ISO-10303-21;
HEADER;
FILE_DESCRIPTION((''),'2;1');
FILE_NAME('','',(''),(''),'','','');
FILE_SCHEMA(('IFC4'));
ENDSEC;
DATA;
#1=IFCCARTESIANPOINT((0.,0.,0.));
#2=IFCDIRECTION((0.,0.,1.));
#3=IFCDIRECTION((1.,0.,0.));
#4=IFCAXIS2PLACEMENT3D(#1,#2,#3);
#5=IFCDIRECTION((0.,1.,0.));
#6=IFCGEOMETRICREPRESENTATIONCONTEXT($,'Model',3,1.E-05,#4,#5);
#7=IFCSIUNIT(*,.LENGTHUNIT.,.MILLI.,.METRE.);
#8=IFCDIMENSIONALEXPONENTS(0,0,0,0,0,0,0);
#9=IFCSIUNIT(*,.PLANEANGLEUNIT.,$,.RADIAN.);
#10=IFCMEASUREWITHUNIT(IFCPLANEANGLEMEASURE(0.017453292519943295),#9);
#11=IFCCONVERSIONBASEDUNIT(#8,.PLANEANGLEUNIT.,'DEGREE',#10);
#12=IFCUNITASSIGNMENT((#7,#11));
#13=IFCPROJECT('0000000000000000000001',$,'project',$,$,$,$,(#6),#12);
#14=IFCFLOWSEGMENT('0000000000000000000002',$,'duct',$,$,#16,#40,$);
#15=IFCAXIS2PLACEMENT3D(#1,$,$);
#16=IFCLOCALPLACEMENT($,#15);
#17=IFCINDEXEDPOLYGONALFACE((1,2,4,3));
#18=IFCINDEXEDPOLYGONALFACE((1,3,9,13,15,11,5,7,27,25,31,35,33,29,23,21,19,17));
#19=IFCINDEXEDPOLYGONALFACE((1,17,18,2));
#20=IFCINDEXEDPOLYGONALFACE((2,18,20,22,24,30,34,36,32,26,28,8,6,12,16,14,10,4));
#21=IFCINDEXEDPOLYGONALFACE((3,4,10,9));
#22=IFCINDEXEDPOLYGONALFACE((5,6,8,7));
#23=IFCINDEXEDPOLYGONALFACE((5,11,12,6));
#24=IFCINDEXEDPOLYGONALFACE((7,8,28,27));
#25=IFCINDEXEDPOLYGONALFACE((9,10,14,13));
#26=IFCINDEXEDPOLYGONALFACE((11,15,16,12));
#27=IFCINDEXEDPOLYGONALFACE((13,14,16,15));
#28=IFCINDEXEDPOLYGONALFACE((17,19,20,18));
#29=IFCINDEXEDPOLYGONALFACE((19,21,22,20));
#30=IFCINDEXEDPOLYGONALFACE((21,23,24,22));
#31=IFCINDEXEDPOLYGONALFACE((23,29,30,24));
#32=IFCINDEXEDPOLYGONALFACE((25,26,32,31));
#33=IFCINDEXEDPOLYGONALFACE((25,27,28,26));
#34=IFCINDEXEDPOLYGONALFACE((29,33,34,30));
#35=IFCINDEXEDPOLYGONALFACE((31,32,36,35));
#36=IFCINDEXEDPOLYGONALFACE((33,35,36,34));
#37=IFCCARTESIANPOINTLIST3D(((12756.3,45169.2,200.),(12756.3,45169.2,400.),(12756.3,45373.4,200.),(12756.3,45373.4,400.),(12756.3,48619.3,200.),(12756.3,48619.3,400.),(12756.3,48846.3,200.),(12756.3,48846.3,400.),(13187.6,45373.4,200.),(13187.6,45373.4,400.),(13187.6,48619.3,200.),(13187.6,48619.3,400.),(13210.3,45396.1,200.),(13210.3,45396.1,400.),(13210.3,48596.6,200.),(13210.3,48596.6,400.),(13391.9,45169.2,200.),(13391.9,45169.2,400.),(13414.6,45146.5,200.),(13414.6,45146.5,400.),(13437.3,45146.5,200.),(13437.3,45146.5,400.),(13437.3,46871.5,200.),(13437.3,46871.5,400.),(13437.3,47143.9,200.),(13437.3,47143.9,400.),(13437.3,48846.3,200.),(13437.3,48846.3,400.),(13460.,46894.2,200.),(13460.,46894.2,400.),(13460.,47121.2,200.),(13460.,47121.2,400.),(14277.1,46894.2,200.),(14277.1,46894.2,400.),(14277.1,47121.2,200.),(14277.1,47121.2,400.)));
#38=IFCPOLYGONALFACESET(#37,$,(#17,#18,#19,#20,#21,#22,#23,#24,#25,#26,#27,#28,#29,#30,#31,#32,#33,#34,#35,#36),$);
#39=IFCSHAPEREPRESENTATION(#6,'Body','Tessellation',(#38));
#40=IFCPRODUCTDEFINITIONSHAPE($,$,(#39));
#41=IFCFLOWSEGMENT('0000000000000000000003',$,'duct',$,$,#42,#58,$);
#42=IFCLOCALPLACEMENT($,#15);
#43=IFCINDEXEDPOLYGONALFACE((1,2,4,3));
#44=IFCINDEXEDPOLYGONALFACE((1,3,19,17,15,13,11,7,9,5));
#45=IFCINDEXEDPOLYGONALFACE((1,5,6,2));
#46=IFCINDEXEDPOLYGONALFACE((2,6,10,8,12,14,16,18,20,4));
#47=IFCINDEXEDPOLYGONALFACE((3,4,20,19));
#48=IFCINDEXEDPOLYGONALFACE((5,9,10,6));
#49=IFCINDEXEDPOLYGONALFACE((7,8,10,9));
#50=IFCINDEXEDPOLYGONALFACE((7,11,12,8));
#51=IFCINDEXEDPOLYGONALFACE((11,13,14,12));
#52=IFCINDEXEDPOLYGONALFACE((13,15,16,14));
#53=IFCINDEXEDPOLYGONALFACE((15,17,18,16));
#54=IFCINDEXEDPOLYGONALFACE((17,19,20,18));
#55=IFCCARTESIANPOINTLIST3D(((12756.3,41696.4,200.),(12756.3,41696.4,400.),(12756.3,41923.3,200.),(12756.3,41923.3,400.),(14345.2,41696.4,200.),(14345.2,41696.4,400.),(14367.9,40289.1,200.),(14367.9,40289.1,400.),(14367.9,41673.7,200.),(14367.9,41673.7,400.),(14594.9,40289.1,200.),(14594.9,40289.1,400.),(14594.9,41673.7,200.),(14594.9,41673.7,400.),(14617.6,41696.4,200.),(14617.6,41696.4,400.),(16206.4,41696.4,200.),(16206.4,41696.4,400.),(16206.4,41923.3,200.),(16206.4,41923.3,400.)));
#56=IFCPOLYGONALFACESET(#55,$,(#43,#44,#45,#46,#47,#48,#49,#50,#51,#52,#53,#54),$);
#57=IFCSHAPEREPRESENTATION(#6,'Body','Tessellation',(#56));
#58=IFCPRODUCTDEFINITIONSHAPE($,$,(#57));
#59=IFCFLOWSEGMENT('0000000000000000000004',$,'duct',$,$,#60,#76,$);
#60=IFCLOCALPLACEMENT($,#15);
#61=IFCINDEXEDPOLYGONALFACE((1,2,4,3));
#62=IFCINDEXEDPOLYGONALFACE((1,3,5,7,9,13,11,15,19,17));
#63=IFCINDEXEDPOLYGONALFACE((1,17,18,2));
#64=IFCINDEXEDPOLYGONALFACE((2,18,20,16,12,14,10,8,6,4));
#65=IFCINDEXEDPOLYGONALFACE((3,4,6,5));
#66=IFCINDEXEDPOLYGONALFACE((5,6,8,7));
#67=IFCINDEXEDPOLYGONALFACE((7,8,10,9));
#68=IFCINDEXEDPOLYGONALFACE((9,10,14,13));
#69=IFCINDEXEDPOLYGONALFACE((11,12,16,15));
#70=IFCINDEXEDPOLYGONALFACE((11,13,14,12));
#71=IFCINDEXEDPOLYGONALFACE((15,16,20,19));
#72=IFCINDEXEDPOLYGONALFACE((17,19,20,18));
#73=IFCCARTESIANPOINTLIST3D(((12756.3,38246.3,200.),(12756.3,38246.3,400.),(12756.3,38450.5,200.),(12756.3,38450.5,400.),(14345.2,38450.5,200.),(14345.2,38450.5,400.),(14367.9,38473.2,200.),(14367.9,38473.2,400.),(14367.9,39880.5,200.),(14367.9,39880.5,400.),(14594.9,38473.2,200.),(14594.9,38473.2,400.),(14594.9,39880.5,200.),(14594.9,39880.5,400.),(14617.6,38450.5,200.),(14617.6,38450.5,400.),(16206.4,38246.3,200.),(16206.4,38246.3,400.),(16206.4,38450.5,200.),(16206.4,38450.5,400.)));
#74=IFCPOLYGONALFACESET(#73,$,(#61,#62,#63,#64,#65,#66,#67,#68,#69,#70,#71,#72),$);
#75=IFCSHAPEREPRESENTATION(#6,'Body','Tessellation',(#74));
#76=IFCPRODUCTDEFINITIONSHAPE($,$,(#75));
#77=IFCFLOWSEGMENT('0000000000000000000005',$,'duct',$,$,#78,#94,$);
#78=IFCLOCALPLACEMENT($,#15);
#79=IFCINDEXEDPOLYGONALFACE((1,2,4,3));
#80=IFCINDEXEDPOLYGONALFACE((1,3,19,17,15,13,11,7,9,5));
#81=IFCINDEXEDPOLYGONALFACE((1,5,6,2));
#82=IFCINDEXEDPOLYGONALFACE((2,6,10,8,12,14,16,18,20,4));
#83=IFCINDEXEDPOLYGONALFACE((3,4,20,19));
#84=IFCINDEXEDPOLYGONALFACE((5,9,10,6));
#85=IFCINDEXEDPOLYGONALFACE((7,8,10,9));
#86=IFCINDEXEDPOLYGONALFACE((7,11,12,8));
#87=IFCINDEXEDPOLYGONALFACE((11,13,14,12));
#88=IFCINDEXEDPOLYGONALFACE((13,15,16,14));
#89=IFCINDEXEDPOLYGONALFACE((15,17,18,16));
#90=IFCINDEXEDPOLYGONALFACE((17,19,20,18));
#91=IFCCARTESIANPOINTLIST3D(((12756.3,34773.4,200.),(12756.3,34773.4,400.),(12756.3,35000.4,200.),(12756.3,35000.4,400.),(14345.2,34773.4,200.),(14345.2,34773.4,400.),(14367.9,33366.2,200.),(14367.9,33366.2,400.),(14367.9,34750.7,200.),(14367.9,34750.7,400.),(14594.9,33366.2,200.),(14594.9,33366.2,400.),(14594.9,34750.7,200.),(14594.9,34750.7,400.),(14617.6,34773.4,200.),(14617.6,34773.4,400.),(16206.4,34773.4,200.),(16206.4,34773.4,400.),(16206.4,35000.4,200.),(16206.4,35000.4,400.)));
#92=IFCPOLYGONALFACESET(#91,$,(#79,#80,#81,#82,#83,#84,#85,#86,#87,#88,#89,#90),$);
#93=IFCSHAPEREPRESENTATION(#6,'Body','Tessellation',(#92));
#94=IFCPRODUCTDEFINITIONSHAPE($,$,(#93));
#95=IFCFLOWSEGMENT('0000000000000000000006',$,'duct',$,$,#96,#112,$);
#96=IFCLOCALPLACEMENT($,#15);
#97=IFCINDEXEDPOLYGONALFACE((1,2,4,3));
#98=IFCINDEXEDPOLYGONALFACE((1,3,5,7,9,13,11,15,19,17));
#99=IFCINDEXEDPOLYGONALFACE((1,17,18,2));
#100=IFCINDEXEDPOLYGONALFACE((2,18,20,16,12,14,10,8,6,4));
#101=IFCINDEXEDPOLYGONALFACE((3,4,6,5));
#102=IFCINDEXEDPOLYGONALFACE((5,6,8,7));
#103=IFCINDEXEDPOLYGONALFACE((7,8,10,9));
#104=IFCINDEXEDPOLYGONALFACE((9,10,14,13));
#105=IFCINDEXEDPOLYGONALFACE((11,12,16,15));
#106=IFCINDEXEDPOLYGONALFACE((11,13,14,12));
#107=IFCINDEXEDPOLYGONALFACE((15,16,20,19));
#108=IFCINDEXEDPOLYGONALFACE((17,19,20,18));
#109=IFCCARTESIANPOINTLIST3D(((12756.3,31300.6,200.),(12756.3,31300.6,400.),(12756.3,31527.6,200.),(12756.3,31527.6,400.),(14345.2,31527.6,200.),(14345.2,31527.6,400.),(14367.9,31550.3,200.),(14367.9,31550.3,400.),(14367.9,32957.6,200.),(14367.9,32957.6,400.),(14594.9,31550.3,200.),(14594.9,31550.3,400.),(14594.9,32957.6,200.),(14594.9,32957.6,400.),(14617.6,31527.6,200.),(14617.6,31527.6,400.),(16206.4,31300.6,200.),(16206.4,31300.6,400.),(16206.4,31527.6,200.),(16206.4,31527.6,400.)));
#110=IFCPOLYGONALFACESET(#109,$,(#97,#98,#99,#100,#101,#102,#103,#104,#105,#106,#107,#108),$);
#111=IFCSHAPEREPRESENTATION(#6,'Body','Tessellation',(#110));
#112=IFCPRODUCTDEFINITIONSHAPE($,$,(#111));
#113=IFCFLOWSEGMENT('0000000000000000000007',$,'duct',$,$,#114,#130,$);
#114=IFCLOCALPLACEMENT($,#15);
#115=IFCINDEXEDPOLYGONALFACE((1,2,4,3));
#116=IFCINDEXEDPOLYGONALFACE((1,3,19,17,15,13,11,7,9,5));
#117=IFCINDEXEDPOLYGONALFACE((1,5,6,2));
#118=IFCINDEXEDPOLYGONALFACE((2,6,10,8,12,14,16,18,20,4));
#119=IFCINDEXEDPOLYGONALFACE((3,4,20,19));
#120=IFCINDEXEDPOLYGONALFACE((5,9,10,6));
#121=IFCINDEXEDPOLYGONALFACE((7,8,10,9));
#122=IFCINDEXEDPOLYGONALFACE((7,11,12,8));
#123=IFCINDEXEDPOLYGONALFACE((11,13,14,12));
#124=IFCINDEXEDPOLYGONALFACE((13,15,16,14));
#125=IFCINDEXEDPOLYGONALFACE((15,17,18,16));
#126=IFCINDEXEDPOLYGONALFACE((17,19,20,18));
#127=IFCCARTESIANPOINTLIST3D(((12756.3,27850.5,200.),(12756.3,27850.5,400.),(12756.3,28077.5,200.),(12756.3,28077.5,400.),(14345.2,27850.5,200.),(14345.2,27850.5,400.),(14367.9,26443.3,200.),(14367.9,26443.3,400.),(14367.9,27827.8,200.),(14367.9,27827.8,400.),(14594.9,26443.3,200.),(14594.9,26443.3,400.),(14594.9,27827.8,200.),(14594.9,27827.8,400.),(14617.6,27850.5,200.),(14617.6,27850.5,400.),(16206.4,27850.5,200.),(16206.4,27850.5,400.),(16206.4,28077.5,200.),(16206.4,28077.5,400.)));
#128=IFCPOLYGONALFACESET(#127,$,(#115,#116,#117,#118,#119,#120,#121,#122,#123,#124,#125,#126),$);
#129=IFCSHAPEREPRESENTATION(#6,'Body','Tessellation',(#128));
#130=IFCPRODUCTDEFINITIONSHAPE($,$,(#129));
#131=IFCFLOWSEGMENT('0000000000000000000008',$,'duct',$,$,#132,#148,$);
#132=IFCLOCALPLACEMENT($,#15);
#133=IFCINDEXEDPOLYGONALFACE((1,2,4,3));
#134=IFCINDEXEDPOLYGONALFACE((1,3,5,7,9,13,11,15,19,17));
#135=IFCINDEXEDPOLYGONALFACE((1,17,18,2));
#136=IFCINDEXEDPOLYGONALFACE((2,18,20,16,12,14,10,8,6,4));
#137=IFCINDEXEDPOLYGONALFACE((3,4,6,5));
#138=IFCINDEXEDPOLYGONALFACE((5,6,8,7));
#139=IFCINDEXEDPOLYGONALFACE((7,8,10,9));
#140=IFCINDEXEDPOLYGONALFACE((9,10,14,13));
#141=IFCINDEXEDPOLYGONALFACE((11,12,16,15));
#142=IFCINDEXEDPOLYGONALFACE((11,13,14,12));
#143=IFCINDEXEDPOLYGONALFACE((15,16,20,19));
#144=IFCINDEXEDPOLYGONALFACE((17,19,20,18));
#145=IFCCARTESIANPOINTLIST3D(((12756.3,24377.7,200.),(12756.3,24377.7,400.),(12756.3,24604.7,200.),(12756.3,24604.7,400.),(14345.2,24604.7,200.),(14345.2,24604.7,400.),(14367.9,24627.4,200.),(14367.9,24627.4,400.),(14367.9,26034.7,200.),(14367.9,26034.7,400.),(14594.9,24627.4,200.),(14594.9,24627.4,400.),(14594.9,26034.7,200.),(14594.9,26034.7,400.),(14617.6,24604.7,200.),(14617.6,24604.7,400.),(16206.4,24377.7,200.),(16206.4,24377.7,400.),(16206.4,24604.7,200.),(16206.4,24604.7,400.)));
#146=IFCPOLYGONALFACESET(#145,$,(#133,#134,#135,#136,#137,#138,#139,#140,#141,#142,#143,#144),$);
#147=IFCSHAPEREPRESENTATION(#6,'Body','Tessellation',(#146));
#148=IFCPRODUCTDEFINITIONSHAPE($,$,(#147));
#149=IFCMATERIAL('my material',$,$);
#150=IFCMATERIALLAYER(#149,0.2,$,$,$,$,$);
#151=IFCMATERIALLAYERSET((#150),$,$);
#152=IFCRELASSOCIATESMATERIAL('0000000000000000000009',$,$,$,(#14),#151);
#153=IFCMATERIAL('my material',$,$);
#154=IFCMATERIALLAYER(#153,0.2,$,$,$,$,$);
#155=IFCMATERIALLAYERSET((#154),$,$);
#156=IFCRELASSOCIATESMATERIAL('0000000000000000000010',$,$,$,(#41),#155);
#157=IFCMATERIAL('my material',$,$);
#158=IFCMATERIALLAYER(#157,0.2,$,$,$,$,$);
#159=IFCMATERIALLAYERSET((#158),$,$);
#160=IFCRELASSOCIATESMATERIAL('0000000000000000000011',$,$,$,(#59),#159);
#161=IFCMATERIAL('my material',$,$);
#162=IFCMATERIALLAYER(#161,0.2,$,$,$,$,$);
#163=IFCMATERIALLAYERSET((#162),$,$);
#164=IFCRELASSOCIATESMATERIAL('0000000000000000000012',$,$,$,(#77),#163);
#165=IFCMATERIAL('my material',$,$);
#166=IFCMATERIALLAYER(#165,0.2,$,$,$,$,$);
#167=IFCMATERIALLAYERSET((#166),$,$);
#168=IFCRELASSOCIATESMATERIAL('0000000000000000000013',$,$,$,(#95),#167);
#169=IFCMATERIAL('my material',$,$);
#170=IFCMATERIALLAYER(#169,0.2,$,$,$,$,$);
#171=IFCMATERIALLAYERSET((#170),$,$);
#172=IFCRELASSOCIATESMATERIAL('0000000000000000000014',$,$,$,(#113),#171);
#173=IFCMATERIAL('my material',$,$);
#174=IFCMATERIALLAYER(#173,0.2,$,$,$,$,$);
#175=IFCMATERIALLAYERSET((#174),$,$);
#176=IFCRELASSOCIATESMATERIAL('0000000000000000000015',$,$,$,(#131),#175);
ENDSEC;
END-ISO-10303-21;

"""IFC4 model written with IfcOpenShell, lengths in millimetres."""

from ifc_helpers import new_model, entity, si_unit, converted_unit, direction, frame, origin_with_axes, place, context, project, polyline, outline, extrude, material, layer, layer_set, layer_usage, element, save


model = new_model("IFC4")

# Units and contexts
model_context = context("Model", 3, precision=1e-05, world=origin_with_axes(), true_north=direction((0.0, 1.0, 0.0)))
ifc_project = project(units=[si_unit("LENGTHUNIT", "METRE", prefix="MILLI"), converted_unit("PLANEANGLEUNIT", "DEGREE", entity("IfcPlaneAngleMeasure", 0.017453292519943295), si_unit("PLANEANGLEUNIT", "RADIAN"), dimensions=[0, 0, 0, 0, 0, 0, 0])], contexts=[model_context])

# Flow segments
ifc_material_1 = material(Name="my material")
ifc_layer_1 = layer(ifc_material_1, 0.2)
ifc_layer_set_1 = layer_set([ifc_layer_1])
ifc_layer_usage_1 = layer_usage(ifc_layer_set_1, "AXIS2", "POSITIVE", -0.1)
flow_segment_1_placement = place(None, origin_with_axes())
element("IfcFlowSegment", 1, at=flow_segment_1_placement, material=ifc_layer_usage_1, Name="duct", context=model_context, shape_type="SweptSolid", body=[
    extrude(outline(polyline([(12756.3, 45169.2), (13391.9, 45169.2), (13414.6, 45146.5), (13437.3, 45146.5), (13437.3, 46871.5), (13460.0, 46894.2), (14277.1, 46894.2), (14277.1, 47121.2), (13460.0, 47121.2), (13437.3, 47143.9), (13437.3, 48846.3), (12756.3, 48846.3), (12756.3, 48619.3), (13187.6, 48619.3), (13210.3, 48596.6), (13210.3, 45396.1), (13187.6, 45373.4), (12756.3, 45373.4), (12756.3, 45169.2)])), frame((0.0, 0.0, 200.0), z_axis=(0.0, 0.0, 1.0), x_axis=(1.0, 0.0, 0.0)), (0.0, 0.0, 1.0), 200.0),
])
ifc_material_2 = material(Name="my material")
ifc_layer_2 = layer(ifc_material_2, 0.2)
ifc_layer_set_2 = layer_set([ifc_layer_2])
ifc_layer_usage_2 = layer_usage(ifc_layer_set_2, "AXIS2", "POSITIVE", -0.1)
flow_segment_2_placement = place(None, origin_with_axes())
element("IfcFlowSegment", 2, at=flow_segment_2_placement, material=ifc_layer_usage_2, Name="duct", context=model_context, shape_type="SweptSolid", body=[
    extrude(outline(polyline([(12756.3, 41696.4), (14345.2, 41696.4), (14367.9, 41673.7), (14367.9, 40289.1), (14594.9, 40289.1), (14594.9, 41673.7), (14617.6, 41696.4), (16206.4, 41696.4), (16206.4, 41923.3), (12756.3, 41923.3), (12756.3, 41696.4)])), frame((0.0, 0.0, 200.0), z_axis=(0.0, 0.0, 1.0), x_axis=(1.0, 0.0, 0.0)), (0.0, 0.0, 1.0), 200.0),
])
ifc_material_3 = material(Name="my material")
ifc_layer_3 = layer(ifc_material_3, 0.2)
ifc_layer_set_3 = layer_set([ifc_layer_3])
ifc_layer_usage_3 = layer_usage(ifc_layer_set_3, "AXIS2", "POSITIVE", -0.1)
flow_segment_3_placement = place(None, origin_with_axes())
element("IfcFlowSegment", 3, at=flow_segment_3_placement, material=ifc_layer_usage_3, Name="duct", context=model_context, shape_type="SweptSolid", body=[
    extrude(outline(polyline([(12756.3, 38246.3), (16206.4, 38246.3), (16206.4, 38450.5), (14617.6, 38450.5), (14594.9, 38473.2), (14594.9, 39880.5), (14367.9, 39880.5), (14367.9, 38473.2), (14345.2, 38450.5), (12756.3, 38450.5), (12756.3, 38246.3)])), frame((0.0, 0.0, 200.0), z_axis=(0.0, 0.0, 1.0), x_axis=(1.0, 0.0, 0.0)), (0.0, 0.0, 1.0), 200.0),
])
ifc_material_4 = material(Name="my material")
ifc_layer_4 = layer(ifc_material_4, 0.2)
ifc_layer_set_4 = layer_set([ifc_layer_4])
ifc_layer_usage_4 = layer_usage(ifc_layer_set_4, "AXIS2", "POSITIVE", -0.1)
flow_segment_4_placement = place(None, origin_with_axes())
element("IfcFlowSegment", 4, at=flow_segment_4_placement, material=ifc_layer_usage_4, Name="duct", context=model_context, shape_type="SweptSolid", body=[
    extrude(outline(polyline([(12756.3, 34773.4), (14345.2, 34773.4), (14367.9, 34750.7), (14367.9, 33366.2), (14594.9, 33366.2), (14594.9, 34750.7), (14617.6, 34773.4), (16206.4, 34773.4), (16206.4, 35000.4), (12756.3, 35000.4), (12756.3, 34773.4)])), frame((0.0, 0.0, 200.0), z_axis=(0.0, 0.0, 1.0), x_axis=(1.0, 0.0, 0.0)), (0.0, 0.0, 1.0), 200.0),
])
ifc_material_5 = material(Name="my material")
ifc_layer_5 = layer(ifc_material_5, 0.2)
ifc_layer_set_5 = layer_set([ifc_layer_5])
ifc_layer_usage_5 = layer_usage(ifc_layer_set_5, "AXIS2", "POSITIVE", -0.1)
flow_segment_5_placement = place(None, origin_with_axes())
element("IfcFlowSegment", 5, at=flow_segment_5_placement, material=ifc_layer_usage_5, Name="duct", context=model_context, shape_type="SweptSolid", body=[
    extrude(outline(polyline([(12756.3, 31300.6), (16206.4, 31300.6), (16206.4, 31527.6), (14617.6, 31527.6), (14594.9, 31550.3), (14594.9, 32957.6), (14367.9, 32957.6), (14367.9, 31550.3), (14345.2, 31527.6), (12756.3, 31527.6), (12756.3, 31300.6)])), frame((0.0, 0.0, 200.0), z_axis=(0.0, 0.0, 1.0), x_axis=(1.0, 0.0, 0.0)), (0.0, 0.0, 1.0), 200.0),
])
ifc_material_6 = material(Name="my material")
ifc_layer_6 = layer(ifc_material_6, 0.2)
ifc_layer_set_6 = layer_set([ifc_layer_6])
ifc_layer_usage_6 = layer_usage(ifc_layer_set_6, "AXIS2", "POSITIVE", -0.1)
flow_segment_6_placement = place(None, origin_with_axes())
element("IfcFlowSegment", 6, at=flow_segment_6_placement, material=ifc_layer_usage_6, Name="duct", context=model_context, shape_type="SweptSolid", body=[
    extrude(outline(polyline([(12756.3, 27850.5), (14345.2, 27850.5), (14367.9, 27827.8), (14367.9, 26443.3), (14594.9, 26443.3), (14594.9, 27827.8), (14617.6, 27850.5), (16206.4, 27850.5), (16206.4, 28077.5), (12756.3, 28077.5), (12756.3, 27850.5)])), frame((0.0, 0.0, 200.0), z_axis=(0.0, 0.0, 1.0), x_axis=(1.0, 0.0, 0.0)), (0.0, 0.0, 1.0), 200.0),
])
ifc_material_7 = material(Name="my material")
ifc_layer_7 = layer(ifc_material_7, 0.2)
ifc_layer_set_7 = layer_set([ifc_layer_7])
ifc_layer_usage_7 = layer_usage(ifc_layer_set_7, "AXIS2", "POSITIVE", -0.1)
flow_segment_7_placement = place(None, origin_with_axes())
element("IfcFlowSegment", 7, at=flow_segment_7_placement, material=ifc_layer_usage_7, Name="duct", context=model_context, shape_type="SweptSolid", body=[
    extrude(outline(polyline([(12756.3, 24377.7), (16206.4, 24377.7), (16206.4, 24604.7), (14617.6, 24604.7), (14594.9, 24627.4), (14594.9, 26034.7), (14367.9, 26034.7), (14367.9, 24627.4), (14345.2, 24604.7), (12756.3, 24604.7), (12756.3, 24377.7)])), frame((0.0, 0.0, 200.0), z_axis=(0.0, 0.0, 1.0), x_axis=(1.0, 0.0, 0.0)), (0.0, 0.0, 1.0), 200.0),
])

save(model, "model.ifc")
